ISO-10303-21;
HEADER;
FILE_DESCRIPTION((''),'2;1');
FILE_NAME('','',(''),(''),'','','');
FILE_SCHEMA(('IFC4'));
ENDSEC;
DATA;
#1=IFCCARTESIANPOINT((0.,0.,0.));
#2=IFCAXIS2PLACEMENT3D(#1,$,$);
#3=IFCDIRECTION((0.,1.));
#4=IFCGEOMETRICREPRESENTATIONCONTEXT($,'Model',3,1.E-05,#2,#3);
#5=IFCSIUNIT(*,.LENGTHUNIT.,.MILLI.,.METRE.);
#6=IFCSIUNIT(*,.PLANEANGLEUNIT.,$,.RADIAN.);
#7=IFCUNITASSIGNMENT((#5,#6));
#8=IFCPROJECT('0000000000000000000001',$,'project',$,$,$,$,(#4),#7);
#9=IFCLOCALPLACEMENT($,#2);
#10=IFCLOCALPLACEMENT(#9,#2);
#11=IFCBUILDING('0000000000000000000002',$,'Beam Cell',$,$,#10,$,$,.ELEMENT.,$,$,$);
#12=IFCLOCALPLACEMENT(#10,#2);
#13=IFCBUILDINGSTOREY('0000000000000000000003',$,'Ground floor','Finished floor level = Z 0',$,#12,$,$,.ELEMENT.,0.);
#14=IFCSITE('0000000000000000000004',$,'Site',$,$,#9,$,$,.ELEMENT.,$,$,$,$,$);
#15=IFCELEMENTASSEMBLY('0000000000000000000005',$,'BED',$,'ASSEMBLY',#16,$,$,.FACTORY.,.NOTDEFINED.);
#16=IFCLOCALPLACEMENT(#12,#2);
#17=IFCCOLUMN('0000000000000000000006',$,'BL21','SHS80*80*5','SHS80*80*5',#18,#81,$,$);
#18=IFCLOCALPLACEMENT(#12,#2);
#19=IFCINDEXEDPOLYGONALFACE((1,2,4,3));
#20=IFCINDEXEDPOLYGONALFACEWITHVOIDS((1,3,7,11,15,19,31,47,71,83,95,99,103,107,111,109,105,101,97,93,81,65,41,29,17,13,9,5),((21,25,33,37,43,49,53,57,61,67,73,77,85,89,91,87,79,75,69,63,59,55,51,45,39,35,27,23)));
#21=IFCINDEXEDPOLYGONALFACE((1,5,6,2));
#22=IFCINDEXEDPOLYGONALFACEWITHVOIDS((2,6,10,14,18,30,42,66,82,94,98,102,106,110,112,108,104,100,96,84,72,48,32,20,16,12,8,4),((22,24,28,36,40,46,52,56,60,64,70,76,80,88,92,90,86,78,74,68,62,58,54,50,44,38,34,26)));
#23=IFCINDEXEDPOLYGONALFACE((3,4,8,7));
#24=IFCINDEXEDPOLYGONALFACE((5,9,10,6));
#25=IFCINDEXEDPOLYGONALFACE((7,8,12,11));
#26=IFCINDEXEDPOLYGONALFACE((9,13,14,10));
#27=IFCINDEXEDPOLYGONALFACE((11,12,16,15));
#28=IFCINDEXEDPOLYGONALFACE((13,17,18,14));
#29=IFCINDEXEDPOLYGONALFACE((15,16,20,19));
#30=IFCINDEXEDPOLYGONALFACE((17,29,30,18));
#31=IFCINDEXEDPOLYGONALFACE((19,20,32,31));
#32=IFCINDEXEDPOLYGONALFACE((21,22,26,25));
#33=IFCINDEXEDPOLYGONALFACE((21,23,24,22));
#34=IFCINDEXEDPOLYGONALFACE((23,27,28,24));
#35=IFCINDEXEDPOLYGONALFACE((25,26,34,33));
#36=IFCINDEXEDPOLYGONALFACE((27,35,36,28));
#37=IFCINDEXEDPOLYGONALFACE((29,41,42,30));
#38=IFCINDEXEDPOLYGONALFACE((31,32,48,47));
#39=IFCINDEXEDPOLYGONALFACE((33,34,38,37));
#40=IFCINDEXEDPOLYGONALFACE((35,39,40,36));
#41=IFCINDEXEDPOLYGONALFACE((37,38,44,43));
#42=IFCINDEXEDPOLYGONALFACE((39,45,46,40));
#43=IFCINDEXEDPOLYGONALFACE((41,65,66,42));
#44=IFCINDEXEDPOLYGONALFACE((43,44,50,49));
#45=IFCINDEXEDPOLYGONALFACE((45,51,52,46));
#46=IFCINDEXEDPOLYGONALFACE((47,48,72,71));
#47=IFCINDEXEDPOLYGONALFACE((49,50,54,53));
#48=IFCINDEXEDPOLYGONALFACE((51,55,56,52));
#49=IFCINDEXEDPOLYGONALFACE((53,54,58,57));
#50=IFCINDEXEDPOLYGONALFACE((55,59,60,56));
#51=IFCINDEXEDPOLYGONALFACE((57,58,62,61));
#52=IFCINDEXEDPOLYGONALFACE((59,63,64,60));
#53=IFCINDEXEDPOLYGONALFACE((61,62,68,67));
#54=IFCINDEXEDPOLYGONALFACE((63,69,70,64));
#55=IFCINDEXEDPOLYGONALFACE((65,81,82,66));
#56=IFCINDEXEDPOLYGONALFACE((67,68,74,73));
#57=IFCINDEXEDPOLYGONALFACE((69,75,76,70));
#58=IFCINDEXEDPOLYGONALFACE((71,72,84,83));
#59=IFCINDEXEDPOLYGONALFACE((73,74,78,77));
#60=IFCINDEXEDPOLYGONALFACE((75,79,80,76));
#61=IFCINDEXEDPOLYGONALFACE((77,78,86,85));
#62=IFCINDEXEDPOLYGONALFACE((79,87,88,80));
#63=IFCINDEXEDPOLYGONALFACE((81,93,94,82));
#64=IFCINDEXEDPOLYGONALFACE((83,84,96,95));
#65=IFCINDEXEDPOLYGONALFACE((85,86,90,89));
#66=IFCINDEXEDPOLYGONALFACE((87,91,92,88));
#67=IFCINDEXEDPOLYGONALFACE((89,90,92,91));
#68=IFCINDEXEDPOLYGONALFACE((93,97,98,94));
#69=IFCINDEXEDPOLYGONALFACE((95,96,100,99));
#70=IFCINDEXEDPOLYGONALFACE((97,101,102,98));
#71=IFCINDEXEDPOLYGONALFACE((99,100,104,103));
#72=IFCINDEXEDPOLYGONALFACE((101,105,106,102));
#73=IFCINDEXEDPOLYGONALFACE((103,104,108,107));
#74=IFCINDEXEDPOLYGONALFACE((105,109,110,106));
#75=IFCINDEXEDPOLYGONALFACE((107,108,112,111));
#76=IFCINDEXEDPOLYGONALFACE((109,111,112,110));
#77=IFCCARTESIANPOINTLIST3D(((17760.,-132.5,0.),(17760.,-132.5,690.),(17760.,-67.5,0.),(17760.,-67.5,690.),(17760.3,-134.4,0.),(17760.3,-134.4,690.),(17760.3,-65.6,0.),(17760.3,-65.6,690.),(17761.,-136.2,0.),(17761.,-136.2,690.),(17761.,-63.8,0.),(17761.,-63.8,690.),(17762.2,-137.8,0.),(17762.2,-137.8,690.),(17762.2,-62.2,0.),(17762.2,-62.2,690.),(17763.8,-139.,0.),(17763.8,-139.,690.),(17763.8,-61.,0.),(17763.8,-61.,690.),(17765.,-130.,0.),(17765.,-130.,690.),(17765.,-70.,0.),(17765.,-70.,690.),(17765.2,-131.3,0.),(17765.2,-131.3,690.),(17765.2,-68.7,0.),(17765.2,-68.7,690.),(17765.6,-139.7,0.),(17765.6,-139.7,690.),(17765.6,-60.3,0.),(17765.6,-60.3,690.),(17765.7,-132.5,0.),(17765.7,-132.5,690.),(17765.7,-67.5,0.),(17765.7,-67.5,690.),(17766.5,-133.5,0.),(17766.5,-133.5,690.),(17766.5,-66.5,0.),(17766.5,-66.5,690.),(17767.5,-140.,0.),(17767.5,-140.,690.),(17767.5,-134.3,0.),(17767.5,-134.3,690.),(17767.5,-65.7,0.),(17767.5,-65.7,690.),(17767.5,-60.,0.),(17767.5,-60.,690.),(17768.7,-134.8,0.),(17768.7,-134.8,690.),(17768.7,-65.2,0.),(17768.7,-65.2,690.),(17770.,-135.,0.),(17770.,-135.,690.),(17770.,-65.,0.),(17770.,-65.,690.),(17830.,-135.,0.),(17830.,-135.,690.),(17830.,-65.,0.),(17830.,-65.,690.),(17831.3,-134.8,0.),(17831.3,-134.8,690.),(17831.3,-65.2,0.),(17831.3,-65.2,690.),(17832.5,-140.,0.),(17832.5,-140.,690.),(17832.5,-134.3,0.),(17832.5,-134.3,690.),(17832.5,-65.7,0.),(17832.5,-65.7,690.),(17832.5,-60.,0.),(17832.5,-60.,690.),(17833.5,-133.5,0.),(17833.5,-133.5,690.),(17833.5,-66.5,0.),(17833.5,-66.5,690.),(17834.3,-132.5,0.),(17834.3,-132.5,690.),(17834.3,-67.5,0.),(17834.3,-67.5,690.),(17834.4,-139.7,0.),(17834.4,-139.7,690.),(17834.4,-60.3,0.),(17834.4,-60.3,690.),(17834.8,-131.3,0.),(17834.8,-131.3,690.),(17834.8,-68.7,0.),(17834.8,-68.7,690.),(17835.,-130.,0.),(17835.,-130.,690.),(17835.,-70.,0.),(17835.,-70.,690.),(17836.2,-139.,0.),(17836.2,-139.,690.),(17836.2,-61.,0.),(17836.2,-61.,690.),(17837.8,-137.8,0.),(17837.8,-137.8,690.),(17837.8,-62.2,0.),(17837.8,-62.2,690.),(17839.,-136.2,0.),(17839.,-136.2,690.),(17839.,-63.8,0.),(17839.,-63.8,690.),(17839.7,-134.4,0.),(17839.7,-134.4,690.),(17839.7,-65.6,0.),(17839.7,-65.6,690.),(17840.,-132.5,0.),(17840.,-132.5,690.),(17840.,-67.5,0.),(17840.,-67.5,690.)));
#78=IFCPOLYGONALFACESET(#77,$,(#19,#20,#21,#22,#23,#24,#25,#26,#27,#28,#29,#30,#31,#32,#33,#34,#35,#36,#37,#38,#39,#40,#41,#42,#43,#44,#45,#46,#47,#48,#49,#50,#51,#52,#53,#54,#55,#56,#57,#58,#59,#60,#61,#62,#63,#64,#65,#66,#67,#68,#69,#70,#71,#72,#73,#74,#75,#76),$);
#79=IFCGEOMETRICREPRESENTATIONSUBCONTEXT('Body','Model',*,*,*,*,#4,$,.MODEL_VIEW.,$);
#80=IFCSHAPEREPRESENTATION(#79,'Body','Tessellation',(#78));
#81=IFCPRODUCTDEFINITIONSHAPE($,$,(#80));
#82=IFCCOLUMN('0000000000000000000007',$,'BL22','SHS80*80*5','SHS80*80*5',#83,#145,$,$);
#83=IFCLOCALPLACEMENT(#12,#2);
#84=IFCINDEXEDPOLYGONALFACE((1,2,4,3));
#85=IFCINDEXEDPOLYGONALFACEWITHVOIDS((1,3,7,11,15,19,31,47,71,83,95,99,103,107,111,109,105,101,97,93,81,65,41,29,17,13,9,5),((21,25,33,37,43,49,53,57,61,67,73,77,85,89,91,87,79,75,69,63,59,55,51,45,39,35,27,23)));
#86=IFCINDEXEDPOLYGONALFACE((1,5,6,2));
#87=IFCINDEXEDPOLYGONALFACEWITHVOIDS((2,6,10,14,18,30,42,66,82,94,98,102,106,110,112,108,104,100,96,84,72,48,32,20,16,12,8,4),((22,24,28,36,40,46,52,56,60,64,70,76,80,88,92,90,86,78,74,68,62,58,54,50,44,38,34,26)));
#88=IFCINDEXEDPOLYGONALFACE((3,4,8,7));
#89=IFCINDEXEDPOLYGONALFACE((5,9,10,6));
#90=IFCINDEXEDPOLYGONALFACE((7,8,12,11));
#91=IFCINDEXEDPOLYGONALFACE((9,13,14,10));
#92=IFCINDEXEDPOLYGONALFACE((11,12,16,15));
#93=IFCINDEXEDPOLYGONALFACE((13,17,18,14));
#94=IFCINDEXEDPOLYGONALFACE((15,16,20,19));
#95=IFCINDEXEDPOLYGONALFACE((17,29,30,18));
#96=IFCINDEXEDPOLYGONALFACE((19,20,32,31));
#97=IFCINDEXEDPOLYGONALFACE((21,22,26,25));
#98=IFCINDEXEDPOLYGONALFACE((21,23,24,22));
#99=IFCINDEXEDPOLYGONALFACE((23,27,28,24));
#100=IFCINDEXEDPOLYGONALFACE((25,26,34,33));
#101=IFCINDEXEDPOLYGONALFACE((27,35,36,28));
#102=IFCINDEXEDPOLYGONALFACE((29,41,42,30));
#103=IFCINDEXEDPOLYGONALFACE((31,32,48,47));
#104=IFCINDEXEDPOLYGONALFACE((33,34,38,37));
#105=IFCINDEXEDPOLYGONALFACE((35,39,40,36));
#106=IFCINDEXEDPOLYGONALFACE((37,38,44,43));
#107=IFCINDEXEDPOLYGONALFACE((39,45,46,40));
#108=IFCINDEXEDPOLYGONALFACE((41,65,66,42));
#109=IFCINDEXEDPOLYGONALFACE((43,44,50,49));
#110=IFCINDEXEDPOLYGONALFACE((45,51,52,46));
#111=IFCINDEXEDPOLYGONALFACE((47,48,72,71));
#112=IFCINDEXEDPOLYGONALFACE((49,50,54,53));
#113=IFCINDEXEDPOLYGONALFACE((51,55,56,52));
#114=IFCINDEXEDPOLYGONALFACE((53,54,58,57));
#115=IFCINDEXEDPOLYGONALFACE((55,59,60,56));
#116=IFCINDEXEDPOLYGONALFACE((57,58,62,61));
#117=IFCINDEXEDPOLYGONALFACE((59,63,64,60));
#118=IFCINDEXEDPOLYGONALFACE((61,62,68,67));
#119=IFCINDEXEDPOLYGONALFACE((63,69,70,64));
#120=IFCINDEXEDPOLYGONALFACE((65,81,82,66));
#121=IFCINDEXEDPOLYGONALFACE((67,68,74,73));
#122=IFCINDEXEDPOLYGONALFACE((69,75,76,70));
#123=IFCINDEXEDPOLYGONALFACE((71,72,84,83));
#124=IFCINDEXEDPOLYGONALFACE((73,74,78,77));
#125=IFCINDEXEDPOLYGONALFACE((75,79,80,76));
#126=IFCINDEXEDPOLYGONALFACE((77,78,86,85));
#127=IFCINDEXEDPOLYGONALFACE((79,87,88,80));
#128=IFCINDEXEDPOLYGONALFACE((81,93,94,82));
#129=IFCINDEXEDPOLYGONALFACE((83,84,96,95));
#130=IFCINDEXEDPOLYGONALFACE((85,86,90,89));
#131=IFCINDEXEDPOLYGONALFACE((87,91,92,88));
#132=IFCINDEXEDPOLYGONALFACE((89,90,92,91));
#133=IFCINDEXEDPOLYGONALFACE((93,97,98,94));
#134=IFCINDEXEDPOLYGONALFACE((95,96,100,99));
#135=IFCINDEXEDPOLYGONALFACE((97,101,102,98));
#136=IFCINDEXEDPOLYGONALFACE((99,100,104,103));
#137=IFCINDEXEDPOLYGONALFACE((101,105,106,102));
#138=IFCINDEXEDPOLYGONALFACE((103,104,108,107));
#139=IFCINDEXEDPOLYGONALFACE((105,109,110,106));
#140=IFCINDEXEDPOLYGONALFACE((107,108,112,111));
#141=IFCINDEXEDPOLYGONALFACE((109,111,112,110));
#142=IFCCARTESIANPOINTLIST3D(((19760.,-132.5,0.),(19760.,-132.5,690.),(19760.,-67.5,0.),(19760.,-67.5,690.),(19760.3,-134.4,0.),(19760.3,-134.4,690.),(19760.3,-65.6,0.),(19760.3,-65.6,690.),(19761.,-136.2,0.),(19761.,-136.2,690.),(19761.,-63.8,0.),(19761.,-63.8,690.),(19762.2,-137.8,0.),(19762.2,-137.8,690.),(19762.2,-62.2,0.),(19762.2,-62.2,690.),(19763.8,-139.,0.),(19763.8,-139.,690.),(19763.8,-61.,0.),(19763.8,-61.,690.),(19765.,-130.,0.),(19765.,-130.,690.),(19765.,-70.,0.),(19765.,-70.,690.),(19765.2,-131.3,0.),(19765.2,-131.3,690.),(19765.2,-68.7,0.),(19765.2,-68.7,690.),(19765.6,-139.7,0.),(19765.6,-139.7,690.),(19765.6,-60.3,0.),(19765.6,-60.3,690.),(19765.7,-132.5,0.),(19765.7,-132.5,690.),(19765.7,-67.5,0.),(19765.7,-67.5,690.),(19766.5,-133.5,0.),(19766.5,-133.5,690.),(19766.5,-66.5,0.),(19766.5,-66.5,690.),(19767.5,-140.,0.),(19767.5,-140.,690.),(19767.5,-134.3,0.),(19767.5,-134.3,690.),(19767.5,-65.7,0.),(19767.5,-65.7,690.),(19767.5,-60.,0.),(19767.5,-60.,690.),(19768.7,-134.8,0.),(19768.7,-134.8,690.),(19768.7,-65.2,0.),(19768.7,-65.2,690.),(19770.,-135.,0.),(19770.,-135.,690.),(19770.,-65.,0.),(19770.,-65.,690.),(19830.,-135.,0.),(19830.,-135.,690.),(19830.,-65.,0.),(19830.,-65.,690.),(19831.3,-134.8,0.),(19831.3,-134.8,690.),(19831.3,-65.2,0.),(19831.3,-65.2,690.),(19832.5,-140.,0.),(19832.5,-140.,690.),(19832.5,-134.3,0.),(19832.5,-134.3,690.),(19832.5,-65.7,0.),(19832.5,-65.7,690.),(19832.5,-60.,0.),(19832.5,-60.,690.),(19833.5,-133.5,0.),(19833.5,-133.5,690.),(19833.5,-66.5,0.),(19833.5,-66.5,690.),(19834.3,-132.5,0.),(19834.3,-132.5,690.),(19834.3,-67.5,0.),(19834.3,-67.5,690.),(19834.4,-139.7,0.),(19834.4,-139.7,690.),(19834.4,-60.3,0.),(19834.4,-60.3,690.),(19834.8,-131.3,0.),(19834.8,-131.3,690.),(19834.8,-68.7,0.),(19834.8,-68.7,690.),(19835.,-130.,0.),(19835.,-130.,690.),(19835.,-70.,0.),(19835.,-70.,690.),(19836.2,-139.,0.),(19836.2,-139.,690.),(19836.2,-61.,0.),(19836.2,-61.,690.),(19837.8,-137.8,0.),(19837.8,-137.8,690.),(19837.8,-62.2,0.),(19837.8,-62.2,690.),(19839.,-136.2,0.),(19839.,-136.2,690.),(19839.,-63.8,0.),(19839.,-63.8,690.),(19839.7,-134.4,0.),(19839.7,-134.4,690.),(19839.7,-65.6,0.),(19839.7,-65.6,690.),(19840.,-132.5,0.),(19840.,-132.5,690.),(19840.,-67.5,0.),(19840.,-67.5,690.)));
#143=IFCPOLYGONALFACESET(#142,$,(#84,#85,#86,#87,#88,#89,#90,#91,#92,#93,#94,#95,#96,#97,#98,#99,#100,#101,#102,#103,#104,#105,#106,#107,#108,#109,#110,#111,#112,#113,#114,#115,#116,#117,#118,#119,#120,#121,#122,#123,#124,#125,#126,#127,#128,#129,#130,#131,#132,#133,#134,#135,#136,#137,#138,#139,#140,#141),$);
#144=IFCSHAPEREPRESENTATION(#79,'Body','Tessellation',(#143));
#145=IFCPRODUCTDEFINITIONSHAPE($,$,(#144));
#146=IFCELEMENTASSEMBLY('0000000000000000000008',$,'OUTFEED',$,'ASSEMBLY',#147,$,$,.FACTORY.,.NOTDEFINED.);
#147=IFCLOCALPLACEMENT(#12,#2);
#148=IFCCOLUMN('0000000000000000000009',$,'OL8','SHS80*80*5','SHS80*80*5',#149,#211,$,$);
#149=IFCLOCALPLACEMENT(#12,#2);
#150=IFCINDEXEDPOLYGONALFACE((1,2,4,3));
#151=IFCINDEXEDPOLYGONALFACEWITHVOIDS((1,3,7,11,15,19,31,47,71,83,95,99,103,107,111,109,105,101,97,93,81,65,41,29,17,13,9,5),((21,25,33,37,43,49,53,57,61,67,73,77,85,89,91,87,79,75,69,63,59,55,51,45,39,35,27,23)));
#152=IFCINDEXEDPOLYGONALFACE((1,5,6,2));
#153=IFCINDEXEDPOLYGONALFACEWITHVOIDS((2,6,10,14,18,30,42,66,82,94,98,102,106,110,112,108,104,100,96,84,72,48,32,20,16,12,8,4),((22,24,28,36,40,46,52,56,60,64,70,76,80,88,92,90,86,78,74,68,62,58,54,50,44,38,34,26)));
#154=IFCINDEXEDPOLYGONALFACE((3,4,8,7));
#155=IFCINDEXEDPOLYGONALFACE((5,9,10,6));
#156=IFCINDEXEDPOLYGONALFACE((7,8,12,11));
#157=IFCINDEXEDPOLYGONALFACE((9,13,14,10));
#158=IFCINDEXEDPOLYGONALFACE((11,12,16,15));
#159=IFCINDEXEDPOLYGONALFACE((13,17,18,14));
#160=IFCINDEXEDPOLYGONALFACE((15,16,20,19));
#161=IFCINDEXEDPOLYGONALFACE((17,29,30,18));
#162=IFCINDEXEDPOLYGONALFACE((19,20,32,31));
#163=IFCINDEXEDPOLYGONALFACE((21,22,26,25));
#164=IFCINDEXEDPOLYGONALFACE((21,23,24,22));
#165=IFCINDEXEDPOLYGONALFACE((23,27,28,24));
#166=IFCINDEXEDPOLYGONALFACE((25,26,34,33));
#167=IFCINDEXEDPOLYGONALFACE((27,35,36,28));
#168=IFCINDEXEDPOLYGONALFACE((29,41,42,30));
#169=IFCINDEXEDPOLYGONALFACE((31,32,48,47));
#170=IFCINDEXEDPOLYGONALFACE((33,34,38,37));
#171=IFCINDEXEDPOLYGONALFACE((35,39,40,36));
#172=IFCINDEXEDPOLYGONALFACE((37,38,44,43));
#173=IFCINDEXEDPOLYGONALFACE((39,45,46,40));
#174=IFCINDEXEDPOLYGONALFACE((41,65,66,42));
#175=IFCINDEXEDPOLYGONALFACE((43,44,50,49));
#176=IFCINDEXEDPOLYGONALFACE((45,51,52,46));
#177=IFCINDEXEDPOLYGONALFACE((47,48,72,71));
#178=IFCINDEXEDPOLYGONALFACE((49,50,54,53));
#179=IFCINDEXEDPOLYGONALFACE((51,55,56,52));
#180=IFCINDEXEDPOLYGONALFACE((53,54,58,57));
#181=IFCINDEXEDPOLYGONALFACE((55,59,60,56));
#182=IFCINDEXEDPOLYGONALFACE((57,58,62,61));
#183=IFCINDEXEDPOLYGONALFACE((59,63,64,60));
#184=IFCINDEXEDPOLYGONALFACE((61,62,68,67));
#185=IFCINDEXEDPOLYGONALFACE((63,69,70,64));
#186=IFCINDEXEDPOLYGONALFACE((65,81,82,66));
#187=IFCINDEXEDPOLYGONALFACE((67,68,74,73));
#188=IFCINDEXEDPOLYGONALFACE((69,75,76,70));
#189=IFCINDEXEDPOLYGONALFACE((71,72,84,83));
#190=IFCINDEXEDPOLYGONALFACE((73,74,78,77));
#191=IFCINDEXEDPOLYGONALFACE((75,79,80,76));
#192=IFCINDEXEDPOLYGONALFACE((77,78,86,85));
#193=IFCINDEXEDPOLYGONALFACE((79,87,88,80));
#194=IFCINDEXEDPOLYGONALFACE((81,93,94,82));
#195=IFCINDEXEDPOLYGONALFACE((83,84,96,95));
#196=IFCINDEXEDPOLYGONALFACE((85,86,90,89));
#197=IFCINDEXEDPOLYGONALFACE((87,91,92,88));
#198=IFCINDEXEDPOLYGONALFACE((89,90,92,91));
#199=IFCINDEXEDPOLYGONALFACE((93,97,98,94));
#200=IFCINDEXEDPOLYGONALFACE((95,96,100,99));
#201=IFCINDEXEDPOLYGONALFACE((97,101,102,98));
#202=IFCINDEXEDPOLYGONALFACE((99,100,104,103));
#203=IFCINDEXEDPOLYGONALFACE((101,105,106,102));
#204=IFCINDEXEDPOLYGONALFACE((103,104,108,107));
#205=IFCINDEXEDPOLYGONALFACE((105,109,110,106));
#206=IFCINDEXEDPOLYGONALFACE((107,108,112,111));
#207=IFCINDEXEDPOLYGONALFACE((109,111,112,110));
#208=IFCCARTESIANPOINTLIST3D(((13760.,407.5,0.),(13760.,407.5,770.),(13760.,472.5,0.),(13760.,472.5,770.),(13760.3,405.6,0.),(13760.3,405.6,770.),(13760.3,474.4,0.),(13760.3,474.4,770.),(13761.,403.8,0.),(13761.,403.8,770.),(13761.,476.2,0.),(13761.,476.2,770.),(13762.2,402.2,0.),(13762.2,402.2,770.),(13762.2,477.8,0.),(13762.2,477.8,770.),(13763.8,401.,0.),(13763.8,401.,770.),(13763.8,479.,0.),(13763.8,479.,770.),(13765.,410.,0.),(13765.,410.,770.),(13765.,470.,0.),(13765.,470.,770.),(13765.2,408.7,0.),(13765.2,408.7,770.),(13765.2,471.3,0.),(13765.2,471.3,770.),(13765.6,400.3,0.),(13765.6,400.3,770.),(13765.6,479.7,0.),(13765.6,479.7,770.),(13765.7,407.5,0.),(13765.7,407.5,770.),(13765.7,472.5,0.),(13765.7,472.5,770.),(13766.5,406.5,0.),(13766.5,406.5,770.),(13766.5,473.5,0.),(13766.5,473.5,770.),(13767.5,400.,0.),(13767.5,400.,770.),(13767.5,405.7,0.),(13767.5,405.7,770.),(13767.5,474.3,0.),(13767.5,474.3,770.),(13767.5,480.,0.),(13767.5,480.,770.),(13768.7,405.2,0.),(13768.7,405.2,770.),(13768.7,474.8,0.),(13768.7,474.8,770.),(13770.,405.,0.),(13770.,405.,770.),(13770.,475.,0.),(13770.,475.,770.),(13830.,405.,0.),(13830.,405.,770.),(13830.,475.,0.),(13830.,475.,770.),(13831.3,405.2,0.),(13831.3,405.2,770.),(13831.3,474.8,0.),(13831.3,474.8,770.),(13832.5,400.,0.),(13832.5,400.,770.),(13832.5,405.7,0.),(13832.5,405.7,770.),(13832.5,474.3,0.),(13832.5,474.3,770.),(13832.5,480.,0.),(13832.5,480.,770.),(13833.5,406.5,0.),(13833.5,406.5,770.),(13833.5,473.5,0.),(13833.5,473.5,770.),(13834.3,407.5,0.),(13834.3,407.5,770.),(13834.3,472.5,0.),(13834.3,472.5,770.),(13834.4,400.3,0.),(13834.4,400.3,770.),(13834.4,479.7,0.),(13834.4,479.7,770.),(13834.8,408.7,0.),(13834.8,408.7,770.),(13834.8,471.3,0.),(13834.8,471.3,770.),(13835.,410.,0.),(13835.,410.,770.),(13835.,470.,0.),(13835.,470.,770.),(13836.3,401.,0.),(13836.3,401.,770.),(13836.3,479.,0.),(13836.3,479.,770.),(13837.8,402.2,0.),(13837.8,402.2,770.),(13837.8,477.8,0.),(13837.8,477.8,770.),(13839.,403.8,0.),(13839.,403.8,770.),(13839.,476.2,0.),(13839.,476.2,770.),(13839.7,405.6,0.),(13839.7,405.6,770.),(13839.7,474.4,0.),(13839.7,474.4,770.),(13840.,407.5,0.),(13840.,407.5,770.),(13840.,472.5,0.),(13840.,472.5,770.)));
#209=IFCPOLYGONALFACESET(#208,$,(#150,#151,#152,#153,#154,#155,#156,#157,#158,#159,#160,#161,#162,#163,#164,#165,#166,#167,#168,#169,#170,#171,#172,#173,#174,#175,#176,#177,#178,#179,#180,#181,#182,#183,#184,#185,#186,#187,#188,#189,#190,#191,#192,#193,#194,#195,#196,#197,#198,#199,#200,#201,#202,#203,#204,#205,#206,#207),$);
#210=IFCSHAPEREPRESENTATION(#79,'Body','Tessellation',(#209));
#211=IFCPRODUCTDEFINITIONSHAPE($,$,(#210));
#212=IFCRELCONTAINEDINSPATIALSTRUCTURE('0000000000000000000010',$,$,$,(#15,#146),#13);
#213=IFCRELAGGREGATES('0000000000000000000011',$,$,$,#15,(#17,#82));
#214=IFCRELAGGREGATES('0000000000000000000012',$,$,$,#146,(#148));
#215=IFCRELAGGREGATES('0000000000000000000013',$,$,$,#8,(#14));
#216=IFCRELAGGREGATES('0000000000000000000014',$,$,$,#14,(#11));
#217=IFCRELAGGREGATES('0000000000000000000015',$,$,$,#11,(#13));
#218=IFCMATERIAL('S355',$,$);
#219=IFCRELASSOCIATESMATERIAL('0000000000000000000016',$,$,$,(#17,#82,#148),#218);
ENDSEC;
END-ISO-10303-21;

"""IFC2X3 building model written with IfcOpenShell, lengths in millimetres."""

from ifc_helpers import new_model, si_unit, direction, frame, origin, origin_2d, place, context, subcontext, project, spatial, hollow_rectangle, extrude, material, element, aggregate, save


model = new_model("IFC2X3")

# Units and contexts
model_context = context("Model", 3, precision=1e-05, world=origin(), true_north=direction((0.0, 1.0)))
body_context = subcontext(model_context, "Body", "Model", "MODEL_VIEW")
ifc_project = project(units=[si_unit("LENGTHUNIT", "METRE", prefix="MILLI"), si_unit("PLANEANGLEUNIT", "RADIAN")], contexts=[model_context])

# Site, building, storey
site_placement = place(None, origin())
site = spatial("IfcSite", under=ifc_project, at=site_placement, Name="Site", CompositionType="ELEMENT")
building_placement = place(site_placement, origin())
building = spatial("IfcBuilding", under=site, at=building_placement, Name="Beam Cell", CompositionType="ELEMENT")
storey_placement = place(building_placement, origin())
storey = spatial("IfcBuildingStorey", under=building, at=storey_placement, Name="Ground floor", Description="Finished floor level = Z 0", CompositionType="ELEMENT", Elevation=0.0)

# Element assemblies, columns
ifc_material = material(Name="S355")
assembly_1_placement = place(storey_placement, origin())
assembly_1 = element("IfcElementAssembly", 1, at=assembly_1_placement, inside=storey, Name="BED", ObjectType="ASSEMBLY", AssemblyPlace="FACTORY", PredefinedType="NOTDEFINED")
column_1_placement = place(storey_placement, frame((17800.0, -100.0, 0.0), z_axis=(0.0, 0.0, 1.0), x_axis=(1.0, 0.0, 0.0)))
column_1 = element("IfcColumn", 2, at=column_1_placement, material=ifc_material, Name="BL21", Description="SHS80*80*5", ObjectType="SHS80*80*5", context=body_context, shape_type="SweptSolid", body=[
    extrude(hollow_rectangle(XDim=80.0, YDim=80.0, WallThickness=5.0, InnerFilletRadius=5.0, OuterFilletRadius=7.5, at=origin_2d()), origin(), (0.0, 0.0, 1.0), 690.0),
])
column_2_placement = place(storey_placement, frame((19800.0, -100.0, 0.0), z_axis=(0.0, 0.0, 1.0), x_axis=(1.0, 0.0, 0.0)))
column_2 = element("IfcColumn", 3, at=column_2_placement, material=ifc_material, Name="BL22", Description="SHS80*80*5", ObjectType="SHS80*80*5", context=body_context, shape_type="SweptSolid", body=[
    extrude(hollow_rectangle(XDim=80.0, YDim=80.0, WallThickness=5.0, InnerFilletRadius=5.0, OuterFilletRadius=7.5, at=origin_2d()), origin(), (0.0, 0.0, 1.0), 690.0),
])
aggregate(assembly_1, [column_1, column_2])
assembly_2_placement = place(storey_placement, origin())
assembly_2 = element("IfcElementAssembly", 4, at=assembly_2_placement, inside=storey, Name="OUTFEED", ObjectType="ASSEMBLY", AssemblyPlace="FACTORY", PredefinedType="NOTDEFINED")
column_3_placement = place(storey_placement, frame((13800.0, 440.0, 0.0), z_axis=(0.0, 0.0, 1.0), x_axis=(1.0, 0.0, 0.0)))
column_3 = element("IfcColumn", 5, at=column_3_placement, material=ifc_material, Name="OL8", Description="SHS80*80*5", ObjectType="SHS80*80*5", context=body_context, shape_type="SweptSolid", body=[
    extrude(hollow_rectangle(XDim=80.0, YDim=80.0, WallThickness=5.0, InnerFilletRadius=5.0, OuterFilletRadius=7.5, at=origin_2d()), origin(), (0.0, 0.0, 1.0), 770.0),
])
aggregate(assembly_2, [column_3])

save(model, "model.ifc")
